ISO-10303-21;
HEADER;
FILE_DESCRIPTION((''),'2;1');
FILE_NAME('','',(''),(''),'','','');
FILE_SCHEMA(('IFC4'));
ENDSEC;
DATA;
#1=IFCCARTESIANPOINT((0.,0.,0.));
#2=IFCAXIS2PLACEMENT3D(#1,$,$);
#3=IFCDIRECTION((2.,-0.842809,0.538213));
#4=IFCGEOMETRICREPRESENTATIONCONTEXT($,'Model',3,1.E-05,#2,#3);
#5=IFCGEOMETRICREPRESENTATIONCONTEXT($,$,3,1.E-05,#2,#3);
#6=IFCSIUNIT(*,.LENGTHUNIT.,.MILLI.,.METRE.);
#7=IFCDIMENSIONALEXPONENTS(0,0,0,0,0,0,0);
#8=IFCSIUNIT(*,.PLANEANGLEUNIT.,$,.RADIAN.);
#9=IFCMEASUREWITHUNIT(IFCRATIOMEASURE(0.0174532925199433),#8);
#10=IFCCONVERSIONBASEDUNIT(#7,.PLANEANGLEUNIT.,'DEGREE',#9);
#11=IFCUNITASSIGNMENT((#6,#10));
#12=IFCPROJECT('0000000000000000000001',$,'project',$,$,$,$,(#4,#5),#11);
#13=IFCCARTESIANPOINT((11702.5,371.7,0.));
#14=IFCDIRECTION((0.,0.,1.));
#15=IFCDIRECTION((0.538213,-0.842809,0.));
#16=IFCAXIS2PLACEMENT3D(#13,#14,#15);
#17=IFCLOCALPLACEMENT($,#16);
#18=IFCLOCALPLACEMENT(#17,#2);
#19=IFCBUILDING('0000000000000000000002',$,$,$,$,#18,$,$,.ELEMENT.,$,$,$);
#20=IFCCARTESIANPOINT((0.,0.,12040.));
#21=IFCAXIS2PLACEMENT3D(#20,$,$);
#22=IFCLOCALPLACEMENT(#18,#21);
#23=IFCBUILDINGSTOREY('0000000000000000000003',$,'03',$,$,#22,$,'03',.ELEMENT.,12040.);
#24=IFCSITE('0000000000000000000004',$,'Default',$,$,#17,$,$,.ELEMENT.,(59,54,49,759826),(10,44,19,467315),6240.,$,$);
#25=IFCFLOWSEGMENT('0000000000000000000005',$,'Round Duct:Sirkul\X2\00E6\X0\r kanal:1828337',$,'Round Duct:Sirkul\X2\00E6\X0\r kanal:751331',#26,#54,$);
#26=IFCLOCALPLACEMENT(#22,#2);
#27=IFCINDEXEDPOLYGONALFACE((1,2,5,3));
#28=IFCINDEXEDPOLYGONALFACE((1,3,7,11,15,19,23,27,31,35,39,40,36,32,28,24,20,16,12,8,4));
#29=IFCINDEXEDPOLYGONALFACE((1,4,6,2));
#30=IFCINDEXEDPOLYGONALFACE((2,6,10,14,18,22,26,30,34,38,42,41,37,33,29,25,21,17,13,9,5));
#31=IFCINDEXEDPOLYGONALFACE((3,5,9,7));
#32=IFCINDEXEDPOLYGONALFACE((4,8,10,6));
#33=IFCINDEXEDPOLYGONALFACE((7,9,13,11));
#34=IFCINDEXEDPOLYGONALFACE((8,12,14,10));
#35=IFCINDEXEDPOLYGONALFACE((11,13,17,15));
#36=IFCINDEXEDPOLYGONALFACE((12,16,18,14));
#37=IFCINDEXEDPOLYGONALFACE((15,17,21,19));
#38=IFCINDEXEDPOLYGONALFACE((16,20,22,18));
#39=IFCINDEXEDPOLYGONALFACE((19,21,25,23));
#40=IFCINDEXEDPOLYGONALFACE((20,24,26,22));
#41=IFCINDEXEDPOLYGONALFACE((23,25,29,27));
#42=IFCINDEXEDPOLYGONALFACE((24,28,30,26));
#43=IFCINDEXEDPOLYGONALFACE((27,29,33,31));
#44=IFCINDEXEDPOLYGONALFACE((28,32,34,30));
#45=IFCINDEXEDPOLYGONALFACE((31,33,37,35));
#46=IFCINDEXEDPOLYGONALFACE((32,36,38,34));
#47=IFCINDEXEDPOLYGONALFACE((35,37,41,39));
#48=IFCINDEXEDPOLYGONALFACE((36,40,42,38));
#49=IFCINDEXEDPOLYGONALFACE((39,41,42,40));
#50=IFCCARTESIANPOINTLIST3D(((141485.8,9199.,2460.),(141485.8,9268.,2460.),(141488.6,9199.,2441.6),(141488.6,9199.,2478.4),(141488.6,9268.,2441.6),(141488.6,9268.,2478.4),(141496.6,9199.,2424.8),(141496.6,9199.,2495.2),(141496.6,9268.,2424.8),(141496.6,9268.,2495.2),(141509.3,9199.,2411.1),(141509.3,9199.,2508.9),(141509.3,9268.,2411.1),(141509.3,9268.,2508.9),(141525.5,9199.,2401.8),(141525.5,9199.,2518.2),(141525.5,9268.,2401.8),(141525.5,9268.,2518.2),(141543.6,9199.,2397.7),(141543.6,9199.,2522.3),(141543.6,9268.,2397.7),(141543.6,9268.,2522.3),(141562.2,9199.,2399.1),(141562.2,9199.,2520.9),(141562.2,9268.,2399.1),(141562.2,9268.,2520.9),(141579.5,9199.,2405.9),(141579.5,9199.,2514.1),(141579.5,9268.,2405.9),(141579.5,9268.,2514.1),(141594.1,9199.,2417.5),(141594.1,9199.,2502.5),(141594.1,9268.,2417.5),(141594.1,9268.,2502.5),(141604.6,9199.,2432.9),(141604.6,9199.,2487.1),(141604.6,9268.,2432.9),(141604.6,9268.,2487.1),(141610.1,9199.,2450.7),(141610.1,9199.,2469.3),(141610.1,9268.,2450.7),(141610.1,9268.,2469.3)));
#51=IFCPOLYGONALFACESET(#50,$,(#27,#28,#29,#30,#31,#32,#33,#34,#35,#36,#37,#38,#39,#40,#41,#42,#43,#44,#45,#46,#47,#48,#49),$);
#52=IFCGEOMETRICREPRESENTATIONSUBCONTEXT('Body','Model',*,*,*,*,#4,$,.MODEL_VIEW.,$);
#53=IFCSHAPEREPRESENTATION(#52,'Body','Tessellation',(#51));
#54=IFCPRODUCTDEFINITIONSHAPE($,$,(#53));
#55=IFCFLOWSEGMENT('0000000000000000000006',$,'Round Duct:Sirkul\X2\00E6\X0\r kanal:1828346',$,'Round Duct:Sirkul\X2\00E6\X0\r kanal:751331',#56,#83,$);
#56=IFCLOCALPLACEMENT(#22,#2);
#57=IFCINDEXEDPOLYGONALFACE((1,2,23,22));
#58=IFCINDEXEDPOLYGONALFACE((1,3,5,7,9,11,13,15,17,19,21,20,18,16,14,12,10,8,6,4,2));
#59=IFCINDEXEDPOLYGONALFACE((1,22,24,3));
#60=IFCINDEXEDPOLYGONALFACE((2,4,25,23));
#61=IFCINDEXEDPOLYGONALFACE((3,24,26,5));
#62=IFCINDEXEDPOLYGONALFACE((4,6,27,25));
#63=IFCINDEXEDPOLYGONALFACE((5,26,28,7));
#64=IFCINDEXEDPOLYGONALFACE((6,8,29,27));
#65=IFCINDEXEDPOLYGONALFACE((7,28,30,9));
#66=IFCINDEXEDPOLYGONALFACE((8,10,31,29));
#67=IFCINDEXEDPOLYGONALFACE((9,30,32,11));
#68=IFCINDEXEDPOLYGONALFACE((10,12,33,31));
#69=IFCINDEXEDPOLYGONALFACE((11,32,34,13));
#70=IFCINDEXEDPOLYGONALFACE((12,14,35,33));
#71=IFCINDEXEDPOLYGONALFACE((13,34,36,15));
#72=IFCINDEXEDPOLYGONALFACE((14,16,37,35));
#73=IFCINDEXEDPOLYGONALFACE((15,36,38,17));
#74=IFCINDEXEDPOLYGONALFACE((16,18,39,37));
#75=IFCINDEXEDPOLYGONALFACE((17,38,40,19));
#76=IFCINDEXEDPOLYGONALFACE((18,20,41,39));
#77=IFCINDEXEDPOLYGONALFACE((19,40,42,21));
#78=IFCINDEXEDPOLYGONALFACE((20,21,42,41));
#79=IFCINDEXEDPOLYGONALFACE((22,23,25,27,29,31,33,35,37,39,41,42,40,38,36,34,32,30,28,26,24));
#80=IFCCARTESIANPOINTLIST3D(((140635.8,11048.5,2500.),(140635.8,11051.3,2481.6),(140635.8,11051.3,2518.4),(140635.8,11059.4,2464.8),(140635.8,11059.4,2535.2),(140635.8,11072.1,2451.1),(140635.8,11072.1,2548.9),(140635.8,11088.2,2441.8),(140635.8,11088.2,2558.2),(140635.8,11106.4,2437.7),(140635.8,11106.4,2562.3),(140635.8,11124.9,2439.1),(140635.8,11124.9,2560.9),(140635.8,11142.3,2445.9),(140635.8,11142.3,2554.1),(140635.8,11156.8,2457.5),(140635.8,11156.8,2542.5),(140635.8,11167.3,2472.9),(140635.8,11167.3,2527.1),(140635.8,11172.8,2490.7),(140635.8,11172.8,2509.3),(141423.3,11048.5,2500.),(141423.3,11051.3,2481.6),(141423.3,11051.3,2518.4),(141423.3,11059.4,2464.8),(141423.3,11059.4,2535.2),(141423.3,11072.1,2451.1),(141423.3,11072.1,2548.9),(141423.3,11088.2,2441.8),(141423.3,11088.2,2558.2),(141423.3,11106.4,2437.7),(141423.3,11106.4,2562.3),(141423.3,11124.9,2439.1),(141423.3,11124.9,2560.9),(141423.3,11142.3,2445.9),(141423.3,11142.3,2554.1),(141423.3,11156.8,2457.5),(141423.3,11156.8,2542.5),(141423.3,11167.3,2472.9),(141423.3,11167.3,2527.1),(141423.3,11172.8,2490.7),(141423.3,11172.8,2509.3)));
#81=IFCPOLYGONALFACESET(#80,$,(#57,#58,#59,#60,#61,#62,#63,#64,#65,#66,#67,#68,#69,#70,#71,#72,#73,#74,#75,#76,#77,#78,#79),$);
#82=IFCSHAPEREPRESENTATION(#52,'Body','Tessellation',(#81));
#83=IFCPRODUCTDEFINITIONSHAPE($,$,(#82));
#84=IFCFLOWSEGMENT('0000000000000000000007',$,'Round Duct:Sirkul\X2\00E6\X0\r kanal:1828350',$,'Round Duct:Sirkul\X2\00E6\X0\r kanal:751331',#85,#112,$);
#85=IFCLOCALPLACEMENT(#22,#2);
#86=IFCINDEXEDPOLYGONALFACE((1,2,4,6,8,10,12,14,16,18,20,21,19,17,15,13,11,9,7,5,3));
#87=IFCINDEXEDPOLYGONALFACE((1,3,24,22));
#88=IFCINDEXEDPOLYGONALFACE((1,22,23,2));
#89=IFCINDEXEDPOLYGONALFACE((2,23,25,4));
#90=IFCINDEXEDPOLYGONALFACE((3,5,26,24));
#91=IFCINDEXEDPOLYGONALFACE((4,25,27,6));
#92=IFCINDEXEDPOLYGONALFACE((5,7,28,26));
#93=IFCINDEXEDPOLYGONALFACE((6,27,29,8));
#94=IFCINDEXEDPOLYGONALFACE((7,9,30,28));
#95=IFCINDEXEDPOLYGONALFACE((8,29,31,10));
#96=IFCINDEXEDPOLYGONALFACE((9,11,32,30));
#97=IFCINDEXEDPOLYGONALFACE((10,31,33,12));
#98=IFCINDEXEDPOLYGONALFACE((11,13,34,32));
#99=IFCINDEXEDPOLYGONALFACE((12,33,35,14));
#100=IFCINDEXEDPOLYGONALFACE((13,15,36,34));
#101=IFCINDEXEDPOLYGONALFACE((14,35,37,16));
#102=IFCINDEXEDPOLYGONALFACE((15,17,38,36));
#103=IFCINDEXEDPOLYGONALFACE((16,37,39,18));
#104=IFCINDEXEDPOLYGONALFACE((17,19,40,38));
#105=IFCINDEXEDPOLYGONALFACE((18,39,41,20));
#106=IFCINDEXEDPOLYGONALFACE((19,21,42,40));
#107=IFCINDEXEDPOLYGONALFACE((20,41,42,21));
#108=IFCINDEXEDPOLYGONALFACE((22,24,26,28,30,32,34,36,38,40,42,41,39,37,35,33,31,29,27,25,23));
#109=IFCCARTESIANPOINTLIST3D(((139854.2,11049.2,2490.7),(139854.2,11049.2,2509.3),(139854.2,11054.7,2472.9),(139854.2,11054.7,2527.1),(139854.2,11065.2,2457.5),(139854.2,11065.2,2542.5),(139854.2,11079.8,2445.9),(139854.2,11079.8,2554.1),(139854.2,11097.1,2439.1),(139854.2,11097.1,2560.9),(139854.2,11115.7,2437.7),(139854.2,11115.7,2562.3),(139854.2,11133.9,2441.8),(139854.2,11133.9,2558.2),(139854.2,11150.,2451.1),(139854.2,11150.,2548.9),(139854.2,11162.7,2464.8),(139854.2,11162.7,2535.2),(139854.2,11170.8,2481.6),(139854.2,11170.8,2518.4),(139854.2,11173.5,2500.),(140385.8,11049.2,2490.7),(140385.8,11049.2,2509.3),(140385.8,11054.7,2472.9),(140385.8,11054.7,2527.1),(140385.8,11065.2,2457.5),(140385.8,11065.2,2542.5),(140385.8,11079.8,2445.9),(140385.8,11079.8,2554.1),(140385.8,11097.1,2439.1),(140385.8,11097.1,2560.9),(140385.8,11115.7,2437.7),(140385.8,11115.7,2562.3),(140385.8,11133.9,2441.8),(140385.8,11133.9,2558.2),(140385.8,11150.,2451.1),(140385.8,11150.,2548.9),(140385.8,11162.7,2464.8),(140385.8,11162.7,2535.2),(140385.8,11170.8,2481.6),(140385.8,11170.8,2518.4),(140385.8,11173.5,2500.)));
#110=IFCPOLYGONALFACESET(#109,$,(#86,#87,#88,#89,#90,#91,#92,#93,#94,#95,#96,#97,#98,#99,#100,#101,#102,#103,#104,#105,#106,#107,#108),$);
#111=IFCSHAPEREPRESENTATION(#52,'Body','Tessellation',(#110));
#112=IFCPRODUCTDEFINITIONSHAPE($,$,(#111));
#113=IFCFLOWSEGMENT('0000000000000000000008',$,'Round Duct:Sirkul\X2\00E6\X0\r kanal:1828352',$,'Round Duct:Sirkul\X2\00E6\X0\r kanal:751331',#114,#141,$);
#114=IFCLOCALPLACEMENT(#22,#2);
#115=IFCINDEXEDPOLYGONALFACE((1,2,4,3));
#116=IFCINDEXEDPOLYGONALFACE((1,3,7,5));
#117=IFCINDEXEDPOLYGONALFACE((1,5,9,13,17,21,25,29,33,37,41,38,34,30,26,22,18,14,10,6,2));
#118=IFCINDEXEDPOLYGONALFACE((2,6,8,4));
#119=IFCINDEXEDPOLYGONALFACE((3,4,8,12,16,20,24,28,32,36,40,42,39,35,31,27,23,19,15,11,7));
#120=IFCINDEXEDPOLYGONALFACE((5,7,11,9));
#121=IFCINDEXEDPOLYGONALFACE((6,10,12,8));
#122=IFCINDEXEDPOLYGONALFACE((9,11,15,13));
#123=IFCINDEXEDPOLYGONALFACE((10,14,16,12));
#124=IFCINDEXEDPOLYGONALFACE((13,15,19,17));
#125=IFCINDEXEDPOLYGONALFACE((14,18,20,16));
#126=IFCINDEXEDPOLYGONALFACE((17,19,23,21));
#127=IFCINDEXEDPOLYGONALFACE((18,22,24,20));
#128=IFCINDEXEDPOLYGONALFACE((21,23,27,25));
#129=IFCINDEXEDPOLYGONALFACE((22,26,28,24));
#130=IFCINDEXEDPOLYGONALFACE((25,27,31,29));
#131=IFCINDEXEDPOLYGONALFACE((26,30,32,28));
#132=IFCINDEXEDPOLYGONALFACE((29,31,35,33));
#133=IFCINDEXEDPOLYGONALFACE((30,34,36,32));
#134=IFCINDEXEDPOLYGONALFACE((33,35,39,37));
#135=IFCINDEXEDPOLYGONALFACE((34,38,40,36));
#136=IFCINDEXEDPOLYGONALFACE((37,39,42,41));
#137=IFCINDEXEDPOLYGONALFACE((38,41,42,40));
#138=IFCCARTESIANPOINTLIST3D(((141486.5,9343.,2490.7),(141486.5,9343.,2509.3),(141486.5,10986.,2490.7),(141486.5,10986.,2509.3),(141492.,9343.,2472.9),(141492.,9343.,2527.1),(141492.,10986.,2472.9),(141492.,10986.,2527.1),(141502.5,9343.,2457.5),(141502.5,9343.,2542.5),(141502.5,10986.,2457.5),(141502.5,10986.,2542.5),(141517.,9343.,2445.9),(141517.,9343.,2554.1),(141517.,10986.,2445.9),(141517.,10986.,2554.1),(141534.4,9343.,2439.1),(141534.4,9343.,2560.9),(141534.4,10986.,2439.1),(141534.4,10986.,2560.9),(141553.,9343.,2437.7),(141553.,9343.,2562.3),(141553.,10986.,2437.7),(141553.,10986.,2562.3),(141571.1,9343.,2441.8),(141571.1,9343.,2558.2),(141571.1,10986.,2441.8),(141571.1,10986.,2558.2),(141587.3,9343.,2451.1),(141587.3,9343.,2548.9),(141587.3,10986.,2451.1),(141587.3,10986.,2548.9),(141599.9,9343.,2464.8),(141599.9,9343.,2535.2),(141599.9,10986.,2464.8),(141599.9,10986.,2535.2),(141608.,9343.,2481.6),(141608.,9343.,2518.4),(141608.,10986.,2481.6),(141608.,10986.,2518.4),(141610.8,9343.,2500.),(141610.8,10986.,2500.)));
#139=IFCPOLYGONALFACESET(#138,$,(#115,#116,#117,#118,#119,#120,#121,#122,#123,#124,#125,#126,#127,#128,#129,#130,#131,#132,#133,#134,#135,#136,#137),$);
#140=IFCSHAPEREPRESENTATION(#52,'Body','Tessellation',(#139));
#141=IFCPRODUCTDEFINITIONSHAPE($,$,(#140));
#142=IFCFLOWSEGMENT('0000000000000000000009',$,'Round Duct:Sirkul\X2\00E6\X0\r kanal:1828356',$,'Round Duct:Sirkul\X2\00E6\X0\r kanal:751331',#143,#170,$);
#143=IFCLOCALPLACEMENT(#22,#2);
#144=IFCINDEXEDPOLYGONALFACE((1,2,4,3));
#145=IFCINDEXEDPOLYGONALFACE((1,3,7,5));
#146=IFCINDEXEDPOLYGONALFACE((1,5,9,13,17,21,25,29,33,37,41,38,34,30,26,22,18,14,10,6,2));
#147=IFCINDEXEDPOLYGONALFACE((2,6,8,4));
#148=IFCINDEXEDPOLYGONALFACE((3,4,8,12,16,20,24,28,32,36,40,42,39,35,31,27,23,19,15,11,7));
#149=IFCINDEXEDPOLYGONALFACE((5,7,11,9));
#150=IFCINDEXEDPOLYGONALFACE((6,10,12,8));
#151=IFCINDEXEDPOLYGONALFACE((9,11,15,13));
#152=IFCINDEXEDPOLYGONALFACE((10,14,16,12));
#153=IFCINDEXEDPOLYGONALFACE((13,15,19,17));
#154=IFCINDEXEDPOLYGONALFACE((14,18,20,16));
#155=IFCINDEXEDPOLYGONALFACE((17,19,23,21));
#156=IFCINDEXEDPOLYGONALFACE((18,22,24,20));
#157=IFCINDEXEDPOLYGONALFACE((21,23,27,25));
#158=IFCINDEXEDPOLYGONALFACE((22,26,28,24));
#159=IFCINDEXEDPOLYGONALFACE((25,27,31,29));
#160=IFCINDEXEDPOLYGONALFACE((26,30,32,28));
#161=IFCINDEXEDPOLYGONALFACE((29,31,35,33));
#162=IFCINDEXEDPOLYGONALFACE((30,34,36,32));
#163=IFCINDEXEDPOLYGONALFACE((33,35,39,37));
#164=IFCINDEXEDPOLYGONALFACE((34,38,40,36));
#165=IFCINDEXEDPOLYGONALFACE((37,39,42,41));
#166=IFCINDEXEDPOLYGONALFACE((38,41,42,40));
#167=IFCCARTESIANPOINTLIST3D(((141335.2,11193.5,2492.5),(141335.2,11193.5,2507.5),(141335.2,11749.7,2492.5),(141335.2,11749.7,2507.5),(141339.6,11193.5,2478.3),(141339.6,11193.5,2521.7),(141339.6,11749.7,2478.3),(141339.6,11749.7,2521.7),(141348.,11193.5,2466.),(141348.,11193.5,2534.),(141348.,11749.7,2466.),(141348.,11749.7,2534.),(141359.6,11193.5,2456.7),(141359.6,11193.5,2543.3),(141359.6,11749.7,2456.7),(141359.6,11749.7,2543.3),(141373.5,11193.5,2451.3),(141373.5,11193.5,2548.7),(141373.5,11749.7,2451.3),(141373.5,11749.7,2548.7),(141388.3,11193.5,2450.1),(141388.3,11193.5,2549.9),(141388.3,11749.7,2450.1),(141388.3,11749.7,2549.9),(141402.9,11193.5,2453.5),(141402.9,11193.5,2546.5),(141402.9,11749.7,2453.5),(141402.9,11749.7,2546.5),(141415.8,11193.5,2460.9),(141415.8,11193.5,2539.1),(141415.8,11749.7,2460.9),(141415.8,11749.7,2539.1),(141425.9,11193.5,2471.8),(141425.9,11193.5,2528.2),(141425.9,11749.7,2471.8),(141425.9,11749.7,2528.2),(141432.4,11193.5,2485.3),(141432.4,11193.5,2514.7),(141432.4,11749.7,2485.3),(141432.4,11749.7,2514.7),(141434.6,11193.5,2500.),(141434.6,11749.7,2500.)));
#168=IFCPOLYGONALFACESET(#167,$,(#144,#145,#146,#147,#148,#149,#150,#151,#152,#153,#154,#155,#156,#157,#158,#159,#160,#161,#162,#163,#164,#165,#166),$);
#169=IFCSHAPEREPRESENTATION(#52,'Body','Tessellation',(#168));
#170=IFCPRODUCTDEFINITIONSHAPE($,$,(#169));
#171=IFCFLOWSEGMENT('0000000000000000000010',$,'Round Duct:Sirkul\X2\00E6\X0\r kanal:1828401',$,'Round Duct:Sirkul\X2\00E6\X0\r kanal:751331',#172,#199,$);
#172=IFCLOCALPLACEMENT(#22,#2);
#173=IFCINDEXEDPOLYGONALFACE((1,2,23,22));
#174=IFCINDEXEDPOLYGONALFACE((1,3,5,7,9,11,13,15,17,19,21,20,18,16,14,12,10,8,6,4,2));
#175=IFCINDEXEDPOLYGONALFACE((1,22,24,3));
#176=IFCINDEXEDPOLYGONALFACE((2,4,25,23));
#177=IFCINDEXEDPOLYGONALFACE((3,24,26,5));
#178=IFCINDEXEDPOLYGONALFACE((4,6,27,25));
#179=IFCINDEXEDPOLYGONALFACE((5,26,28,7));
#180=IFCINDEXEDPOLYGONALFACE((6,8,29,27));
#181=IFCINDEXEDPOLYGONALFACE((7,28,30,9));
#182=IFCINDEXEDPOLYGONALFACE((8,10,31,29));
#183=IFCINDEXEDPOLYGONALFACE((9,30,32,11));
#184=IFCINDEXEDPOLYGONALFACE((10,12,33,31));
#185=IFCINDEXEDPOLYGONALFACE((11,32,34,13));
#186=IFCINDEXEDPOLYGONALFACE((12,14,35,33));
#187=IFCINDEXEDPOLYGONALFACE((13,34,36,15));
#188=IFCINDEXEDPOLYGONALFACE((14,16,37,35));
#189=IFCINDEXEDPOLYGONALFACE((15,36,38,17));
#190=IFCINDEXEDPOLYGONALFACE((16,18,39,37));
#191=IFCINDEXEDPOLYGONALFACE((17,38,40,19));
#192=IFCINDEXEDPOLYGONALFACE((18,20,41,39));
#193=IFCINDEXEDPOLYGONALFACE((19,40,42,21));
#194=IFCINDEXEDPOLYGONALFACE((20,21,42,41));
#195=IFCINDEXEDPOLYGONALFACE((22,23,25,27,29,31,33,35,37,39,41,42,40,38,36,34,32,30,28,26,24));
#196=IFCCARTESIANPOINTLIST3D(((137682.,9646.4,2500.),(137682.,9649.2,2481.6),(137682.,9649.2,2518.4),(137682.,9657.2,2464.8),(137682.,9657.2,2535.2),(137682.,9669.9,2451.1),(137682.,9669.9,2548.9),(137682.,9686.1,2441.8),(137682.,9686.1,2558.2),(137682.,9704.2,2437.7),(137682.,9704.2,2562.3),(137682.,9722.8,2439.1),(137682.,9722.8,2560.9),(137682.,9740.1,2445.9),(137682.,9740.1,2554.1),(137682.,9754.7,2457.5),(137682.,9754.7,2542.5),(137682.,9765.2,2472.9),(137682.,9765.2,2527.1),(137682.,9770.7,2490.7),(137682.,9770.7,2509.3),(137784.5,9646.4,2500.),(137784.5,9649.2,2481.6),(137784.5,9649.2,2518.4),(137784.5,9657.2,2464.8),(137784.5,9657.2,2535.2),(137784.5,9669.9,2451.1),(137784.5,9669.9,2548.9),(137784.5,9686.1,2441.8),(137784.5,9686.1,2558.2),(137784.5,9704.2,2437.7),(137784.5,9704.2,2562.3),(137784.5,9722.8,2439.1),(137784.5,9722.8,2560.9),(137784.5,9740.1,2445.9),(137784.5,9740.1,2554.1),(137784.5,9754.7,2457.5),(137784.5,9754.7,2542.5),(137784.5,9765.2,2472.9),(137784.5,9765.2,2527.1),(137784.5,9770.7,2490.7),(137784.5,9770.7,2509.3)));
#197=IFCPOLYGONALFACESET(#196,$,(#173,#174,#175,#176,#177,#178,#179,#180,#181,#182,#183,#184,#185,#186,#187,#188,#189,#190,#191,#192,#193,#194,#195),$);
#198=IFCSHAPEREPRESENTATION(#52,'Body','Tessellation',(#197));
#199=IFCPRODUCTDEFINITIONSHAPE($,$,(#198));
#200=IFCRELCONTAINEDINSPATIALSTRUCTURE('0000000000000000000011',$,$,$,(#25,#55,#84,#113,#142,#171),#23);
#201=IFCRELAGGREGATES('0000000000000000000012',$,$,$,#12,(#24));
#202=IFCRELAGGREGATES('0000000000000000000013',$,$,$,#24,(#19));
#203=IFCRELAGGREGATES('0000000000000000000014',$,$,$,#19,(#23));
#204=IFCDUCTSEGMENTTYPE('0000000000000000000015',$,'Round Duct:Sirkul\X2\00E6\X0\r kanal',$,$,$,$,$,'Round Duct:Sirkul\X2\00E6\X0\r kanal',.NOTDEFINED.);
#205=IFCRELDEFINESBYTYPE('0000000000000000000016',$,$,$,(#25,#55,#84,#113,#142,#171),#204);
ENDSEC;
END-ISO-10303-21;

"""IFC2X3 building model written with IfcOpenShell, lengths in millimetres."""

from ifc_helpers import new_model, entity, si_unit, converted_unit, direction, frame, frame_2d, origin, origin_2d_with_axis, place, context, subcontext, project, spatial, circle, extrude, type_object, element, save


model = new_model("IFC2X3")

# Units and contexts
model_context = context("Model", 3, precision=1e-05, world=origin(), true_north=direction((2.0, -0.842809, 0.538213)))
context_of_model = context(None, 3, precision=1e-05, world=origin(), true_north=direction((2.0, -0.842809, 0.538213)))
body_context = subcontext(model_context, "Body", "Model", "MODEL_VIEW")
ifc_project = project(units=[si_unit("LENGTHUNIT", "METRE", prefix="MILLI"), converted_unit("PLANEANGLEUNIT", "DEGREE", entity("IfcRatioMeasure", 0.0174532925199433), si_unit("PLANEANGLEUNIT", "RADIAN"), dimensions=[0, 0, 0, 0, 0, 0, 0])], contexts=[model_context, context_of_model])

# Site, building, storey
site_placement = place(None, frame((11702.5, 371.7, 0.0), z_axis=(0.0, 0.0, 1.0), x_axis=(0.538213, -0.842809, 0.0)))
site = spatial("IfcSite", under=ifc_project, at=site_placement, Name="Default", CompositionType="ELEMENT", RefLatitude=(59, 54, 49, 759826), RefLongitude=(10, 44, 19, 467315), RefElevation=6240.0)
building_placement = place(site_placement, origin())
building = spatial("IfcBuilding", under=site, at=building_placement, CompositionType="ELEMENT")
storey_placement = place(building_placement, frame((0.0, 0.0, 12040.0)))
storey = spatial("IfcBuildingStorey", under=building, at=storey_placement, Name="03", LongName="03", CompositionType="ELEMENT", Elevation=12040.0)

# Flow segments
duct_segment_type_1 = type_object("IfcDuctSegmentType", Name="Round Duct:Sirkulær kanal", ElementType="Round Duct:Sirkulær kanal", PredefinedType="NOTDEFINED")
flow_segment_1_placement = place(storey_placement, origin())
element("IfcFlowSegment", 1, at=flow_segment_1_placement, inside=storey, type_object=duct_segment_type_1, Name="Round Duct:Sirkulær kanal:1828337", ObjectType="Round Duct:Sirkulær kanal:751331", context=body_context, shape_type="SweptSolid", body=[
    extrude(circle(Radius=62.5, at=origin_2d_with_axis()), frame((141548.3, 9199.0, 2460.0), z_axis=(0.0, 1.0, 0.0), x_axis=(-1.0, 0.0, 0.0)), (0.0, 0.0, 1.0), 69.0),
])
flow_segment_2_placement = place(storey_placement, origin())
element("IfcFlowSegment", 2, at=flow_segment_2_placement, inside=storey, type_object=duct_segment_type_1, Name="Round Duct:Sirkulær kanal:1828346", ObjectType="Round Duct:Sirkulær kanal:751331", context=body_context, shape_type="SweptSolid", body=[
    extrude(circle(Radius=62.5, at=frame_2d((0.0, 0.0), x_axis=(1.0, 0.0))), frame((140635.8, 11111.0, 2500.0), z_axis=(1.0, 0.0, 0.0), x_axis=(0.0, -1.0, 0.0)), (0.0, 0.0, 1.0), 787.5),
])
flow_segment_3_placement = place(storey_placement, origin())
element("IfcFlowSegment", 3, at=flow_segment_3_placement, inside=storey, type_object=duct_segment_type_1, Name="Round Duct:Sirkulær kanal:1828350", ObjectType="Round Duct:Sirkulær kanal:751331", context=body_context, shape_type="SweptSolid", body=[
    extrude(circle(Radius=62.5, at=frame_2d((0.0, 0.0), x_axis=(1.0, 0.0))), frame((139854.2, 11111.0, 2500.0), z_axis=(1.0, 0.0, 0.0), x_axis=(0.0, 1.0, 0.0)), (0.0, 0.0, 1.0), 531.6),
])
flow_segment_4_placement = place(storey_placement, origin())
element("IfcFlowSegment", 4, at=flow_segment_4_placement, inside=storey, type_object=duct_segment_type_1, Name="Round Duct:Sirkulær kanal:1828352", ObjectType="Round Duct:Sirkulær kanal:751331", context=body_context, shape_type="SweptSolid", body=[
    extrude(circle(Radius=62.5, at=origin_2d_with_axis()), frame((141548.3, 9343.0, 2500.0), z_axis=(0.0, 1.0, 0.0), x_axis=(1.0, 0.0, 0.0)), (0.0, 0.0, 1.0), 1643.0),
])
flow_segment_5_placement = place(storey_placement, origin())
element("IfcFlowSegment", 5, at=flow_segment_5_placement, inside=storey, type_object=duct_segment_type_1, Name="Round Duct:Sirkulær kanal:1828356", ObjectType="Round Duct:Sirkulær kanal:751331", context=body_context, shape_type="SweptSolid", body=[
    extrude(circle(Radius=50.0, at=origin_2d_with_axis()), frame((141384.6, 11193.5, 2500.0), z_axis=(0.0, 1.0, 0.0), x_axis=(1.0, 0.0, 0.0)), (0.0, 0.0, 1.0), 556.2),
])
flow_segment_6_placement = place(storey_placement, origin())
element("IfcFlowSegment", 6, at=flow_segment_6_placement, inside=storey, type_object=duct_segment_type_1, Name="Round Duct:Sirkulær kanal:1828401", ObjectType="Round Duct:Sirkulær kanal:751331", context=body_context, shape_type="SweptSolid", body=[
    extrude(circle(Radius=62.5, at=frame_2d((0.0, 0.0), x_axis=(1.0, 0.0))), frame((137682.0, 9708.9, 2500.0), z_axis=(1.0, 0.0, 0.0), x_axis=(0.0, -1.0, 0.0)), (0.0, 0.0, 1.0), 102.5),
])

save(model, "model.ifc")
